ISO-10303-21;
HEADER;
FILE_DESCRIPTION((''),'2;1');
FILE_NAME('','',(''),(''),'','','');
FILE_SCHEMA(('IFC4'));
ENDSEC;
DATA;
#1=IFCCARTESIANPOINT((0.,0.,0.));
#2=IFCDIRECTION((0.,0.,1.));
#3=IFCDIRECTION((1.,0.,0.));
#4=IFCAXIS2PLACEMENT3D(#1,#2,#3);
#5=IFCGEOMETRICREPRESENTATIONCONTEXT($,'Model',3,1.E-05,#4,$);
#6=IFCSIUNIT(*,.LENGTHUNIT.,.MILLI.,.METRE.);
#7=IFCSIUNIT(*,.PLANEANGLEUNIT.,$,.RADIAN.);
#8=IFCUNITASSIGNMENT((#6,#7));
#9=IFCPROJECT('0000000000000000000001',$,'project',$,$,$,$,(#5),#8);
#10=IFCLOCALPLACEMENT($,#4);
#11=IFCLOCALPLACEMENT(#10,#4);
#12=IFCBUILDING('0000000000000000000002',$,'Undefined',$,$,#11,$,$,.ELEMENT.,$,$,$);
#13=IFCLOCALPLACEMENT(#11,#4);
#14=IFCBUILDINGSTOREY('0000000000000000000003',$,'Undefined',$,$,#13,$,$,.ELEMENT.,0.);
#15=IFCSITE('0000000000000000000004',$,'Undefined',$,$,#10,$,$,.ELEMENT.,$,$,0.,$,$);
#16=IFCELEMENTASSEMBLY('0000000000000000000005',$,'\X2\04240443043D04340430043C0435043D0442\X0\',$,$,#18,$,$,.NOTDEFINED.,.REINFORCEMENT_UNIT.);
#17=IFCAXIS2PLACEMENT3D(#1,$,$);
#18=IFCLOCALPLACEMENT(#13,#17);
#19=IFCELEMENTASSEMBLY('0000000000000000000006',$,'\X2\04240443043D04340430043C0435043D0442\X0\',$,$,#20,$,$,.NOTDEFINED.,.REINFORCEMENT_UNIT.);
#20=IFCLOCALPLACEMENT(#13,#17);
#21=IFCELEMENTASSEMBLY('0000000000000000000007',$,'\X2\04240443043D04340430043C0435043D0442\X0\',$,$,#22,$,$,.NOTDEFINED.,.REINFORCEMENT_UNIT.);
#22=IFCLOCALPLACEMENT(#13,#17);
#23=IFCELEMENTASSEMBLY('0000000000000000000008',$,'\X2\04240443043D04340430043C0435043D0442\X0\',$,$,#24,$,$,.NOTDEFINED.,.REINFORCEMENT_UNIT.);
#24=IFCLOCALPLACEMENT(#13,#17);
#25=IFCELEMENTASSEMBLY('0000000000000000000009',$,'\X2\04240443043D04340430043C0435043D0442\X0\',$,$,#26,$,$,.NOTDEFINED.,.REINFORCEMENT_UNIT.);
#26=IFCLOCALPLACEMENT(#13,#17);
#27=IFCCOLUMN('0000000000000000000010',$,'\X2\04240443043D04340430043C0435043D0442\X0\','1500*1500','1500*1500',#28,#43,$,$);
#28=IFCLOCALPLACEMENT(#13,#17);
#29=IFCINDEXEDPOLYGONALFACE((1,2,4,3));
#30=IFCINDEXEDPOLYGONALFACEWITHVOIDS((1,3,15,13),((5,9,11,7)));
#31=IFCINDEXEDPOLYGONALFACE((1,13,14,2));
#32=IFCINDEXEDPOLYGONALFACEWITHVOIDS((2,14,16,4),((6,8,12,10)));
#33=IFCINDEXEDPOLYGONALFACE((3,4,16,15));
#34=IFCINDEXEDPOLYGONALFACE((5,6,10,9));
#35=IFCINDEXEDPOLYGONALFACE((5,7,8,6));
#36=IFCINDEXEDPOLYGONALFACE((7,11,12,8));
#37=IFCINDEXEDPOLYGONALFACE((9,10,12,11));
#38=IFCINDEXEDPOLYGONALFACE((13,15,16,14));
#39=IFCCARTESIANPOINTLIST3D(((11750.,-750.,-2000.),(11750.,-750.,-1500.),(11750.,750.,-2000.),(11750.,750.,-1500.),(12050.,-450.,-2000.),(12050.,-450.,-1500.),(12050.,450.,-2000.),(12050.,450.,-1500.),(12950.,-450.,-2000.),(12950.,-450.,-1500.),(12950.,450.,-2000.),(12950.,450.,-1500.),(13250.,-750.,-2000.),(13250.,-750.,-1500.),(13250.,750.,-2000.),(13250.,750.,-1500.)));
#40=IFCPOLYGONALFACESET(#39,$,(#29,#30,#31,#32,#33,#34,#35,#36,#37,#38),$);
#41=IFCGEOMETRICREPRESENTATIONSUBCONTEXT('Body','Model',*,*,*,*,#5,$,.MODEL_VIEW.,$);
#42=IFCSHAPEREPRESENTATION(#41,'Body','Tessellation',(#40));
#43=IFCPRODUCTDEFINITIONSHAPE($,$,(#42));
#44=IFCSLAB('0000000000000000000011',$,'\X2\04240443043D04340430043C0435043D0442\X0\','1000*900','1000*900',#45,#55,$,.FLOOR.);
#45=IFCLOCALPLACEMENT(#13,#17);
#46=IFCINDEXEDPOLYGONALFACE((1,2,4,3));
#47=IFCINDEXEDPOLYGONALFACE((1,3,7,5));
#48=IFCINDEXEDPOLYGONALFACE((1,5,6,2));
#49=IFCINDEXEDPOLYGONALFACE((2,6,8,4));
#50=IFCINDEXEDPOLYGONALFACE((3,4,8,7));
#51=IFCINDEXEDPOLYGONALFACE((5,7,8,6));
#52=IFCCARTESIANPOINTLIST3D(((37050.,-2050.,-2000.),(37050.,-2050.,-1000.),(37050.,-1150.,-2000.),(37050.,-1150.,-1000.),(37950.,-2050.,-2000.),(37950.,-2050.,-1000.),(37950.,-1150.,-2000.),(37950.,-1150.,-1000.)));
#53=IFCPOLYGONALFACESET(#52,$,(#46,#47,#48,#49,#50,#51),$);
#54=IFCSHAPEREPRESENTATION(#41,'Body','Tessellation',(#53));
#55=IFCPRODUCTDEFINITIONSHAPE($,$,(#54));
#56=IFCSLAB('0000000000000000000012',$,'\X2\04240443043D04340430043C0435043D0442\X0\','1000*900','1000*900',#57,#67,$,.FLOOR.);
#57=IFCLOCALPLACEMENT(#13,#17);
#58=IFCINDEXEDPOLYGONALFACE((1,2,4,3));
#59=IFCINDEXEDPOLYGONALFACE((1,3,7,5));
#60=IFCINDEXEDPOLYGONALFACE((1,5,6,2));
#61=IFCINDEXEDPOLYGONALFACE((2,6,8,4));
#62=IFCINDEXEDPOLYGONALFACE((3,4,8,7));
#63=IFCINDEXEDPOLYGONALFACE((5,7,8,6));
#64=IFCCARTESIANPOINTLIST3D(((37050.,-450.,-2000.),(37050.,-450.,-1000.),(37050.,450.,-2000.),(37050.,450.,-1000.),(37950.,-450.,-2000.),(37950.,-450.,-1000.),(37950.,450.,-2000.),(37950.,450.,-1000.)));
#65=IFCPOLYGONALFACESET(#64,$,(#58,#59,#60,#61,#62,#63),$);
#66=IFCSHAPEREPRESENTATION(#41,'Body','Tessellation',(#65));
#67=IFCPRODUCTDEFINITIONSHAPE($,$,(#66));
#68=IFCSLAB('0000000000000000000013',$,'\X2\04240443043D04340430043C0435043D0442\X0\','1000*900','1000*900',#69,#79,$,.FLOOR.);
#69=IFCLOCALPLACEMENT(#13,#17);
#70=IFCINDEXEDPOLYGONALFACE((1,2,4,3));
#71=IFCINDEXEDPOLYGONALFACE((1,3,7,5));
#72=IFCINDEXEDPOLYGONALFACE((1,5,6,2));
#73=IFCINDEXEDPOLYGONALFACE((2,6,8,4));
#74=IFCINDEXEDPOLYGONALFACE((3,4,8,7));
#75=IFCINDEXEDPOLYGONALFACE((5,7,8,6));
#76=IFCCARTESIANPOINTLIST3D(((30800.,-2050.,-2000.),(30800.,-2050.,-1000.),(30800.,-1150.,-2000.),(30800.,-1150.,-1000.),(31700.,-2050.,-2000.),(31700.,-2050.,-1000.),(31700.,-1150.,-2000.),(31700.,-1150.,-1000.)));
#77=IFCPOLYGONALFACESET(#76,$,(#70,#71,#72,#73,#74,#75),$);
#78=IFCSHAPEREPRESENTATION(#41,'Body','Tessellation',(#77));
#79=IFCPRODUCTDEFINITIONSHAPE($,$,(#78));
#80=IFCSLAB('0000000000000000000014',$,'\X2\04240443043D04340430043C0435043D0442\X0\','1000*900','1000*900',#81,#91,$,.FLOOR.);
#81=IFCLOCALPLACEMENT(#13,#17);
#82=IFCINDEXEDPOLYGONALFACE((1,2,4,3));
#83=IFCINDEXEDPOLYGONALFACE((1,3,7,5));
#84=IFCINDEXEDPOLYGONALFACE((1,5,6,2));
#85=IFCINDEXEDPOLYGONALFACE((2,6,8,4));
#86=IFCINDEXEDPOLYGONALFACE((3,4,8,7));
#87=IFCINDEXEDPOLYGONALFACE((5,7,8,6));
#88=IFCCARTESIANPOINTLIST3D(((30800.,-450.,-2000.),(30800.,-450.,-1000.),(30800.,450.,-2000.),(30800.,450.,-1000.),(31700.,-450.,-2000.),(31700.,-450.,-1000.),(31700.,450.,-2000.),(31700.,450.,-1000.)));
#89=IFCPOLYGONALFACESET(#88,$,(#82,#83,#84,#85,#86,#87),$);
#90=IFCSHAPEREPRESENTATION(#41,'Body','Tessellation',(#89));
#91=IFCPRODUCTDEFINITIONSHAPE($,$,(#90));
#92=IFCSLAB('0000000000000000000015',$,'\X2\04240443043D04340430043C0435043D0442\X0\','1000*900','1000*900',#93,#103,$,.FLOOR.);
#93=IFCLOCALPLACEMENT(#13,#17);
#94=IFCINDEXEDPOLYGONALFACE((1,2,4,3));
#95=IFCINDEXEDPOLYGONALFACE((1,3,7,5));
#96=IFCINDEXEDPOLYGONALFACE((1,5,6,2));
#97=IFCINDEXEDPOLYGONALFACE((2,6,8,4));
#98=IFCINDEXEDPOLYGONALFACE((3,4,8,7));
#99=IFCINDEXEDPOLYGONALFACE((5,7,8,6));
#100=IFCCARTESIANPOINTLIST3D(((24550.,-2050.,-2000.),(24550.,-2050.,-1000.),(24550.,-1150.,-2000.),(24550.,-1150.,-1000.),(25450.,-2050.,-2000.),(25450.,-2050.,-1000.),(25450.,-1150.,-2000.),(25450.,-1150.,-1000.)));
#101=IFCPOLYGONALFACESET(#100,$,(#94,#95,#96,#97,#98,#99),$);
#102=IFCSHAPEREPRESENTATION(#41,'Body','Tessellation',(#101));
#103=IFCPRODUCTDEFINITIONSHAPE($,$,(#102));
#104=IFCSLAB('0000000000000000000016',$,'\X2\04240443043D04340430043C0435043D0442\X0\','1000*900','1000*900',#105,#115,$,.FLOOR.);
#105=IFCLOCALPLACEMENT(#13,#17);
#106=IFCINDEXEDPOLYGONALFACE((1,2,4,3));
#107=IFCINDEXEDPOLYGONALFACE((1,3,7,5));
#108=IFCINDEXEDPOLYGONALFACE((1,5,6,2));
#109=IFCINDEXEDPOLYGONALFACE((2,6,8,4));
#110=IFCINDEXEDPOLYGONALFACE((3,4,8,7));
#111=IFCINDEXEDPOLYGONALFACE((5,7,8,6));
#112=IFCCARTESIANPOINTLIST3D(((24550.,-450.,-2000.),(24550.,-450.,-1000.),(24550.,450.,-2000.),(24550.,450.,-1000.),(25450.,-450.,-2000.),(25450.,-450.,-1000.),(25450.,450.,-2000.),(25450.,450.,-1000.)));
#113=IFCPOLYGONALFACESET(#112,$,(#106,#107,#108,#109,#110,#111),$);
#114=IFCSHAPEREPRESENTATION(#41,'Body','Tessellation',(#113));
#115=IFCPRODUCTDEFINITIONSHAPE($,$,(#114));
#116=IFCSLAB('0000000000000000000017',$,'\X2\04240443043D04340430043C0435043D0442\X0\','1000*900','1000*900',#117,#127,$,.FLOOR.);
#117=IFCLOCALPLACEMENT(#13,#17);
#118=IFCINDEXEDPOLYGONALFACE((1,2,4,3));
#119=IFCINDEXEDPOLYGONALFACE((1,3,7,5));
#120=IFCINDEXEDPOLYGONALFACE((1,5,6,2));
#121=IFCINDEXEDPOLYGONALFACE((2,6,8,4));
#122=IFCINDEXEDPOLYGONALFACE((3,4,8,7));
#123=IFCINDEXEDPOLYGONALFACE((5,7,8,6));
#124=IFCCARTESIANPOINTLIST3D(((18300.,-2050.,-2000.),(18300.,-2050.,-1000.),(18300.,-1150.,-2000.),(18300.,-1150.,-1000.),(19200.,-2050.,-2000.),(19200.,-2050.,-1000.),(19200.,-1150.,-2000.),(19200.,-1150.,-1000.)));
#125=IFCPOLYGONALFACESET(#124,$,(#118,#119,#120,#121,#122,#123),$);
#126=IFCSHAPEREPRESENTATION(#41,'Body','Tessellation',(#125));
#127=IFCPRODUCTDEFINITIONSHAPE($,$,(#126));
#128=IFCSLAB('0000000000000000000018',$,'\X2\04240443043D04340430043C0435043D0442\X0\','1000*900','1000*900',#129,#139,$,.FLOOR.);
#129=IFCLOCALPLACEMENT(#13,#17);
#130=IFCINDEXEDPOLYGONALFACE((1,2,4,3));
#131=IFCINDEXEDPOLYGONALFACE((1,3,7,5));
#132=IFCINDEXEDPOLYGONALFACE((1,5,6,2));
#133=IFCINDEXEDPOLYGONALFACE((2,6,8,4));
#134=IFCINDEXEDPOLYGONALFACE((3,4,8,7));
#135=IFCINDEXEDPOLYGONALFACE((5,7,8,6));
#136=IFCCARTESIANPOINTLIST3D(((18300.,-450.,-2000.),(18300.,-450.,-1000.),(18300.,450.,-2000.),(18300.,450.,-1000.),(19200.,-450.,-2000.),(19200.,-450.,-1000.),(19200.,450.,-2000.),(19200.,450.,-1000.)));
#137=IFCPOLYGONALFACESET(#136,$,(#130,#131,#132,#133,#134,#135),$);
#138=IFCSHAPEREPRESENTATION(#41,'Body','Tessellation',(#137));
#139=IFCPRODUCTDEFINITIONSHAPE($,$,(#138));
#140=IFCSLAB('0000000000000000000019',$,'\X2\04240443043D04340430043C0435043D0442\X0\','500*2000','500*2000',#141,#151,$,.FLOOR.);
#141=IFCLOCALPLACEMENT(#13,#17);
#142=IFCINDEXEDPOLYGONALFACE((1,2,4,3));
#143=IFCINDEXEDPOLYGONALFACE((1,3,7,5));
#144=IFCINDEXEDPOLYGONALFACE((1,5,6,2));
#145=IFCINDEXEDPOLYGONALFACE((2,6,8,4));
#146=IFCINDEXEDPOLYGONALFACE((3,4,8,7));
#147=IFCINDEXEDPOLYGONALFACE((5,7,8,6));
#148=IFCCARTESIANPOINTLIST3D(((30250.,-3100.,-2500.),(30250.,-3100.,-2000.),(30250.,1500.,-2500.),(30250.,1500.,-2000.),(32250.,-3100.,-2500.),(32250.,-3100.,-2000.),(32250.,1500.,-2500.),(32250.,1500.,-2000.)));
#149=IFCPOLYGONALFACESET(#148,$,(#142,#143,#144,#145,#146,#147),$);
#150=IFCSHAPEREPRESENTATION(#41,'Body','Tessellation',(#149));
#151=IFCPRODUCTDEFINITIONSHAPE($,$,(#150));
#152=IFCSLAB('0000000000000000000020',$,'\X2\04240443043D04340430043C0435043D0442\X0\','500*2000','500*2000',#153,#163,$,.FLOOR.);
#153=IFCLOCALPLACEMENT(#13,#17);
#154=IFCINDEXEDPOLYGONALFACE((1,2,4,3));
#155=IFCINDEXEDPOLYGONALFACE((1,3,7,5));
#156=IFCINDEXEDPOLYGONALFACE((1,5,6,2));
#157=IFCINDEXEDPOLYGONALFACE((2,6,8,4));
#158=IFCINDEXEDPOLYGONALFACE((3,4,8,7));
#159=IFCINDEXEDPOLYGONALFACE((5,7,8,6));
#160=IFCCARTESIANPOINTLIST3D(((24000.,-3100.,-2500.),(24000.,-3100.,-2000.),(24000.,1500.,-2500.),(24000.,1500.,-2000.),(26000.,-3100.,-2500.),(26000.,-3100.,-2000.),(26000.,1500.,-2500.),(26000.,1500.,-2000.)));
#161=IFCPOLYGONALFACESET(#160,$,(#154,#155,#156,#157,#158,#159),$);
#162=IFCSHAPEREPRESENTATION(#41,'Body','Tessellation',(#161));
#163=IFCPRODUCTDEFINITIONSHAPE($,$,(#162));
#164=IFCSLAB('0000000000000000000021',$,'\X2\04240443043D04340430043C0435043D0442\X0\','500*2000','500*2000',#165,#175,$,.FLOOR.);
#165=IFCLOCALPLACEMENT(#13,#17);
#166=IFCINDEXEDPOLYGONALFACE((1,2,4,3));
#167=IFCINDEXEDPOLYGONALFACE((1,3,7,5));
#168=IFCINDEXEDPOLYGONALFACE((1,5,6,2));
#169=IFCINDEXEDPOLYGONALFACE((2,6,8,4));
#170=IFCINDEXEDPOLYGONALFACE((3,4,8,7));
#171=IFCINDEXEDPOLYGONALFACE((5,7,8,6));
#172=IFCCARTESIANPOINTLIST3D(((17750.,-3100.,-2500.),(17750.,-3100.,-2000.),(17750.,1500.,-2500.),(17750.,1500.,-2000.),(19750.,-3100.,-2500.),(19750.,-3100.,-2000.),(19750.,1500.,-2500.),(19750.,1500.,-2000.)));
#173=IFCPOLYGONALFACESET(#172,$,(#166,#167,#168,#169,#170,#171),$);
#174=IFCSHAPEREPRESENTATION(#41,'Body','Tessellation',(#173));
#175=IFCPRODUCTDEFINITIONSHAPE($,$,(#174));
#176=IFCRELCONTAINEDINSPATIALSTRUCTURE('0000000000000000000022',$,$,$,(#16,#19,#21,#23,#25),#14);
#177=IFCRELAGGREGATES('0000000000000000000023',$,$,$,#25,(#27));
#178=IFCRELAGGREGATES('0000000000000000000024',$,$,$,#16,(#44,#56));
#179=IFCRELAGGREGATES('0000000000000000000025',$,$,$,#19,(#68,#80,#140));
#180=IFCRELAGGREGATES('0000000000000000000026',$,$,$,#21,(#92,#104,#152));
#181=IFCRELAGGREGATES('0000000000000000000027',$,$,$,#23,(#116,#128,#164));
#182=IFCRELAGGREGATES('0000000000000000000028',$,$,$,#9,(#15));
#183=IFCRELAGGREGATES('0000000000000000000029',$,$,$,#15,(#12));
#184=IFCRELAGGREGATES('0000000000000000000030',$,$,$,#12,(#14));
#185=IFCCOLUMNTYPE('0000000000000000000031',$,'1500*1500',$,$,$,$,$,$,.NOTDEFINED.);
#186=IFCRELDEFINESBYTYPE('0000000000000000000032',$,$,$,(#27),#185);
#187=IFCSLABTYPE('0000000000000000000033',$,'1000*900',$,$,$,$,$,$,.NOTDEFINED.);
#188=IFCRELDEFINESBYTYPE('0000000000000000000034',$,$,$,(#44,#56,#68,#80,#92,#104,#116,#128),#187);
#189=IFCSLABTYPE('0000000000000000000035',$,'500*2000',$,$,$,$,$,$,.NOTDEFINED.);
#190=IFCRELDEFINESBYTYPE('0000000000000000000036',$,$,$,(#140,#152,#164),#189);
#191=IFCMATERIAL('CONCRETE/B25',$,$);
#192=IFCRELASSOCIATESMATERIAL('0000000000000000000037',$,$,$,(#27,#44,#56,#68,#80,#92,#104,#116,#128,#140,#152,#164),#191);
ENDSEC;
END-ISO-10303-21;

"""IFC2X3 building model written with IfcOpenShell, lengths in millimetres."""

from ifc_helpers import new_model, si_unit, frame, origin_with_axes, origin_2d_with_axis, place, context, subcontext, project, spatial, polyline, rectangle, outline, extrude, boolean, material, type_object, element, aggregate, save


model = new_model("IFC2X3")

# Units and contexts
model_context = context("Model", 3, precision=1e-05, world=origin_with_axes())
body_context = subcontext(model_context, "Body", "Model", "MODEL_VIEW")
ifc_project = project(units=[si_unit("LENGTHUNIT", "METRE", prefix="MILLI"), si_unit("PLANEANGLEUNIT", "RADIAN")], contexts=[model_context])

# Site, building, storey
site_placement = place(None, origin_with_axes())
site = spatial("IfcSite", under=ifc_project, at=site_placement, Name="Undefined", CompositionType="ELEMENT", RefElevation=0.0)
building_placement = place(site_placement, origin_with_axes())
building = spatial("IfcBuilding", under=site, at=building_placement, Name="Undefined", CompositionType="ELEMENT")
storey_placement = place(building_placement, origin_with_axes())
storey = spatial("IfcBuildingStorey", under=building, at=storey_placement, Name="Undefined", CompositionType="ELEMENT", Elevation=0.0)

# Element assemblies
assembly_1_placement = place(storey_placement, origin_with_axes())
assembly_1 = element("IfcElementAssembly", 1, at=assembly_1_placement, inside=storey, Name="Фундамент", AssemblyPlace="NOTDEFINED", PredefinedType="REINFORCEMENT_UNIT")
ifc_material = material(Name="CONCRETE/B25")
assembly_2_placement = place(storey_placement, origin_with_axes())
assembly_2 = element("IfcElementAssembly", 2, at=assembly_2_placement, inside=storey, Name="Фундамент", AssemblyPlace="NOTDEFINED", PredefinedType="REINFORCEMENT_UNIT")
assembly_3_placement = place(storey_placement, origin_with_axes())
assembly_3 = element("IfcElementAssembly", 3, at=assembly_3_placement, inside=storey, Name="Фундамент", AssemblyPlace="NOTDEFINED", PredefinedType="REINFORCEMENT_UNIT")
assembly_4_placement = place(storey_placement, origin_with_axes())
assembly_4 = element("IfcElementAssembly", 4, at=assembly_4_placement, inside=storey, Name="Фундамент", AssemblyPlace="NOTDEFINED", PredefinedType="REINFORCEMENT_UNIT")
assembly_5_placement = place(storey_placement, origin_with_axes())
assembly_5 = element("IfcElementAssembly", 5, at=assembly_5_placement, inside=storey, Name="Фундамент", AssemblyPlace="NOTDEFINED", PredefinedType="REINFORCEMENT_UNIT")

# Column
column_type_1 = type_object("IfcColumnType", Name="1500*1500", PredefinedType="NOTDEFINED")
column_1_placement = place(assembly_5_placement, frame((12500.0, 0.0, -2000.0), z_axis=(0.0, 0.0, 1.0), x_axis=(0.0, -1.0, 0.0)))
column_1 = element("IfcColumn", 6, at=column_1_placement, type_object=column_type_1, material=ifc_material, Name="Фундамент", Description="1500*1500", ObjectType="1500*1500", context=body_context, shape_type="CSG", body=[
    boolean("DIFFERENCE", extrude(rectangle(XDim=1500.0, YDim=1500.0, at=origin_2d_with_axis()), frame((0.0, 0.0, 500.0), z_axis=(0.0, 0.0, -1.0), x_axis=(0.0, 1.0, 0.0)), (0.0, 0.0, 1.0), 500.0), extrude(outline(polyline([(0.0, 0.0), (900.0, 0.0), (900.0, 900.0), (0.0, 900.0), (0.0, 0.0)])), frame((-450.0, -450.0, -100.0), z_axis=(0.0, 0.0, 1.0), x_axis=(1.0, 0.0, 0.0)), (0.0, 0.0, 1.0), 700.0)),
])
aggregate(assembly_5, [column_1])

# Slabs
slab_type_1 = type_object("IfcSlabType", Name="1000*900", PredefinedType="NOTDEFINED")
slab_1_placement = place(assembly_1_placement, frame((37050.0, -1150.0, -1500.0), z_axis=(0.0, 0.0, 1.0), x_axis=(0.0, -1.0, 0.0)))
slab_1 = element("IfcSlab", 7, at=slab_1_placement, type_object=slab_type_1, material=ifc_material, Name="Фундамент", Description="1000*900", ObjectType="1000*900", PredefinedType="FLOOR", context=body_context, shape_type="SweptSolid", body=[
    extrude(outline(polyline([(0.0, 0.0), (900.0, 0.0), (900.0, 900.0), (0.0, 900.0), (0.0, 0.0)])), frame((0.0, 0.0, -500.0), z_axis=(0.0, 0.0, 1.0), x_axis=(1.0, 0.0, 0.0)), (0.0, 0.0, 1.0), 1000.0),
])
slab_2_placement = place(assembly_1_placement, frame((37050.0, 450.0, -1500.0), z_axis=(0.0, 0.0, 1.0), x_axis=(0.0, -1.0, 0.0)))
slab_2 = element("IfcSlab", 8, at=slab_2_placement, type_object=slab_type_1, material=ifc_material, Name="Фундамент", Description="1000*900", ObjectType="1000*900", PredefinedType="FLOOR", context=body_context, shape_type="SweptSolid", body=[
    extrude(outline(polyline([(0.0, 0.0), (900.0, 0.0), (900.0, 900.0), (0.0, 900.0), (0.0, 0.0)])), frame((0.0, 0.0, -500.0), z_axis=(0.0, 0.0, 1.0), x_axis=(1.0, 0.0, 0.0)), (0.0, 0.0, 1.0), 1000.0),
])
aggregate(assembly_1, [slab_1, slab_2])
slab_3_placement = place(assembly_2_placement, frame((30800.0, -1150.0, -1500.0), z_axis=(0.0, 0.0, 1.0), x_axis=(0.0, -1.0, 0.0)))
slab_3 = element("IfcSlab", 9, at=slab_3_placement, type_object=slab_type_1, material=ifc_material, Name="Фундамент", Description="1000*900", ObjectType="1000*900", PredefinedType="FLOOR", context=body_context, shape_type="SweptSolid", body=[
    extrude(outline(polyline([(0.0, 0.0), (900.0, 0.0), (900.0, 900.0), (0.0, 900.0), (0.0, 0.0)])), frame((0.0, 0.0, -500.0), z_axis=(0.0, 0.0, 1.0), x_axis=(1.0, 0.0, 0.0)), (0.0, 0.0, 1.0), 1000.0),
])
slab_4_placement = place(assembly_2_placement, frame((30800.0, 450.0, -1500.0), z_axis=(0.0, 0.0, 1.0), x_axis=(0.0, -1.0, 0.0)))
slab_4 = element("IfcSlab", 10, at=slab_4_placement, type_object=slab_type_1, material=ifc_material, Name="Фундамент", Description="1000*900", ObjectType="1000*900", PredefinedType="FLOOR", context=body_context, shape_type="SweptSolid", body=[
    extrude(outline(polyline([(0.0, 0.0), (900.0, 0.0), (900.0, 900.0), (0.0, 900.0), (0.0, 0.0)])), frame((0.0, 0.0, -500.0), z_axis=(0.0, 0.0, 1.0), x_axis=(1.0, 0.0, 0.0)), (0.0, 0.0, 1.0), 1000.0),
])
slab_5_placement = place(assembly_3_placement, frame((24550.0, -1150.0, -1500.0), z_axis=(0.0, 0.0, 1.0), x_axis=(0.0, -1.0, 0.0)))
slab_5 = element("IfcSlab", 11, at=slab_5_placement, type_object=slab_type_1, material=ifc_material, Name="Фундамент", Description="1000*900", ObjectType="1000*900", PredefinedType="FLOOR", context=body_context, shape_type="SweptSolid", body=[
    extrude(outline(polyline([(0.0, 0.0), (900.0, 0.0), (900.0, 900.0), (0.0, 900.0), (0.0, 0.0)])), frame((0.0, 0.0, -500.0), z_axis=(0.0, 0.0, 1.0), x_axis=(1.0, 0.0, 0.0)), (0.0, 0.0, 1.0), 1000.0),
])
slab_6_placement = place(assembly_3_placement, frame((24550.0, 450.0, -1500.0), z_axis=(0.0, 0.0, 1.0), x_axis=(0.0, -1.0, 0.0)))
slab_6 = element("IfcSlab", 12, at=slab_6_placement, type_object=slab_type_1, material=ifc_material, Name="Фундамент", Description="1000*900", ObjectType="1000*900", PredefinedType="FLOOR", context=body_context, shape_type="SweptSolid", body=[
    extrude(outline(polyline([(0.0, 0.0), (900.0, 0.0), (900.0, 900.0), (0.0, 900.0), (0.0, 0.0)])), frame((0.0, 0.0, -500.0), z_axis=(0.0, 0.0, 1.0), x_axis=(1.0, 0.0, 0.0)), (0.0, 0.0, 1.0), 1000.0),
])
slab_7_placement = place(assembly_4_placement, frame((18300.0, -1150.0, -1500.0), z_axis=(0.0, 0.0, 1.0), x_axis=(0.0, -1.0, 0.0)))
slab_7 = element("IfcSlab", 13, at=slab_7_placement, type_object=slab_type_1, material=ifc_material, Name="Фундамент", Description="1000*900", ObjectType="1000*900", PredefinedType="FLOOR", context=body_context, shape_type="SweptSolid", body=[
    extrude(outline(polyline([(0.0, 0.0), (900.0, 0.0), (900.0, 900.0), (0.0, 900.0), (0.0, 0.0)])), frame((0.0, 0.0, -500.0), z_axis=(0.0, 0.0, 1.0), x_axis=(1.0, 0.0, 0.0)), (0.0, 0.0, 1.0), 1000.0),
])
slab_8_placement = place(assembly_4_placement, frame((18300.0, 450.0, -1500.0), z_axis=(0.0, 0.0, 1.0), x_axis=(0.0, -1.0, 0.0)))
slab_8 = element("IfcSlab", 14, at=slab_8_placement, type_object=slab_type_1, material=ifc_material, Name="Фундамент", Description="1000*900", ObjectType="1000*900", PredefinedType="FLOOR", context=body_context, shape_type="SweptSolid", body=[
    extrude(outline(polyline([(0.0, 0.0), (900.0, 0.0), (900.0, 900.0), (0.0, 900.0), (0.0, 0.0)])), frame((0.0, 0.0, -500.0), z_axis=(0.0, 0.0, 1.0), x_axis=(1.0, 0.0, 0.0)), (0.0, 0.0, 1.0), 1000.0),
])
slab_type_2 = type_object("IfcSlabType", Name="500*2000", PredefinedType="NOTDEFINED")
slab_9_placement = place(assembly_2_placement, frame((30250.0, 1500.0, -2250.0), z_axis=(0.0, 0.0, 1.0), x_axis=(0.0, -1.0, 0.0)))
slab_9 = element("IfcSlab", 15, at=slab_9_placement, type_object=slab_type_2, material=ifc_material, Name="Фундамент", Description="500*2000", ObjectType="500*2000", PredefinedType="FLOOR", context=body_context, shape_type="SweptSolid", body=[
    extrude(outline(polyline([(0.0, 0.0), (4600.0, 0.0), (4600.0, 2000.0), (0.0, 2000.0), (0.0, 0.0)])), frame((0.0, 0.0, -250.0), z_axis=(0.0, 0.0, 1.0), x_axis=(1.0, 0.0, 0.0)), (0.0, 0.0, 1.0), 500.0),
])
aggregate(assembly_2, [slab_3, slab_4, slab_9])
slab_10_placement = place(assembly_3_placement, frame((24000.0, 1500.0, -2250.0), z_axis=(0.0, 0.0, 1.0), x_axis=(0.0, -1.0, 0.0)))
slab_10 = element("IfcSlab", 16, at=slab_10_placement, type_object=slab_type_2, material=ifc_material, Name="Фундамент", Description="500*2000", ObjectType="500*2000", PredefinedType="FLOOR", context=body_context, shape_type="SweptSolid", body=[
    extrude(outline(polyline([(0.0, 0.0), (4600.0, 0.0), (4600.0, 2000.0), (0.0, 2000.0), (0.0, 0.0)])), frame((0.0, 0.0, -250.0), z_axis=(0.0, 0.0, 1.0), x_axis=(1.0, 0.0, 0.0)), (0.0, 0.0, 1.0), 500.0),
])
aggregate(assembly_3, [slab_5, slab_6, slab_10])
slab_11_placement = place(assembly_4_placement, frame((17750.0, 1500.0, -2250.0), z_axis=(0.0, 0.0, 1.0), x_axis=(0.0, -1.0, 0.0)))
slab_11 = element("IfcSlab", 17, at=slab_11_placement, type_object=slab_type_2, material=ifc_material, Name="Фундамент", Description="500*2000", ObjectType="500*2000", PredefinedType="FLOOR", context=body_context, shape_type="SweptSolid", body=[
    extrude(outline(polyline([(0.0, 0.0), (4600.0, 0.0), (4600.0, 2000.0), (0.0, 2000.0), (0.0, 0.0)])), frame((0.0, 0.0, -250.0), z_axis=(0.0, 0.0, 1.0), x_axis=(1.0, 0.0, 0.0)), (0.0, 0.0, 1.0), 500.0),
])
aggregate(assembly_4, [slab_7, slab_8, slab_11])

save(model, "model.ifc")
